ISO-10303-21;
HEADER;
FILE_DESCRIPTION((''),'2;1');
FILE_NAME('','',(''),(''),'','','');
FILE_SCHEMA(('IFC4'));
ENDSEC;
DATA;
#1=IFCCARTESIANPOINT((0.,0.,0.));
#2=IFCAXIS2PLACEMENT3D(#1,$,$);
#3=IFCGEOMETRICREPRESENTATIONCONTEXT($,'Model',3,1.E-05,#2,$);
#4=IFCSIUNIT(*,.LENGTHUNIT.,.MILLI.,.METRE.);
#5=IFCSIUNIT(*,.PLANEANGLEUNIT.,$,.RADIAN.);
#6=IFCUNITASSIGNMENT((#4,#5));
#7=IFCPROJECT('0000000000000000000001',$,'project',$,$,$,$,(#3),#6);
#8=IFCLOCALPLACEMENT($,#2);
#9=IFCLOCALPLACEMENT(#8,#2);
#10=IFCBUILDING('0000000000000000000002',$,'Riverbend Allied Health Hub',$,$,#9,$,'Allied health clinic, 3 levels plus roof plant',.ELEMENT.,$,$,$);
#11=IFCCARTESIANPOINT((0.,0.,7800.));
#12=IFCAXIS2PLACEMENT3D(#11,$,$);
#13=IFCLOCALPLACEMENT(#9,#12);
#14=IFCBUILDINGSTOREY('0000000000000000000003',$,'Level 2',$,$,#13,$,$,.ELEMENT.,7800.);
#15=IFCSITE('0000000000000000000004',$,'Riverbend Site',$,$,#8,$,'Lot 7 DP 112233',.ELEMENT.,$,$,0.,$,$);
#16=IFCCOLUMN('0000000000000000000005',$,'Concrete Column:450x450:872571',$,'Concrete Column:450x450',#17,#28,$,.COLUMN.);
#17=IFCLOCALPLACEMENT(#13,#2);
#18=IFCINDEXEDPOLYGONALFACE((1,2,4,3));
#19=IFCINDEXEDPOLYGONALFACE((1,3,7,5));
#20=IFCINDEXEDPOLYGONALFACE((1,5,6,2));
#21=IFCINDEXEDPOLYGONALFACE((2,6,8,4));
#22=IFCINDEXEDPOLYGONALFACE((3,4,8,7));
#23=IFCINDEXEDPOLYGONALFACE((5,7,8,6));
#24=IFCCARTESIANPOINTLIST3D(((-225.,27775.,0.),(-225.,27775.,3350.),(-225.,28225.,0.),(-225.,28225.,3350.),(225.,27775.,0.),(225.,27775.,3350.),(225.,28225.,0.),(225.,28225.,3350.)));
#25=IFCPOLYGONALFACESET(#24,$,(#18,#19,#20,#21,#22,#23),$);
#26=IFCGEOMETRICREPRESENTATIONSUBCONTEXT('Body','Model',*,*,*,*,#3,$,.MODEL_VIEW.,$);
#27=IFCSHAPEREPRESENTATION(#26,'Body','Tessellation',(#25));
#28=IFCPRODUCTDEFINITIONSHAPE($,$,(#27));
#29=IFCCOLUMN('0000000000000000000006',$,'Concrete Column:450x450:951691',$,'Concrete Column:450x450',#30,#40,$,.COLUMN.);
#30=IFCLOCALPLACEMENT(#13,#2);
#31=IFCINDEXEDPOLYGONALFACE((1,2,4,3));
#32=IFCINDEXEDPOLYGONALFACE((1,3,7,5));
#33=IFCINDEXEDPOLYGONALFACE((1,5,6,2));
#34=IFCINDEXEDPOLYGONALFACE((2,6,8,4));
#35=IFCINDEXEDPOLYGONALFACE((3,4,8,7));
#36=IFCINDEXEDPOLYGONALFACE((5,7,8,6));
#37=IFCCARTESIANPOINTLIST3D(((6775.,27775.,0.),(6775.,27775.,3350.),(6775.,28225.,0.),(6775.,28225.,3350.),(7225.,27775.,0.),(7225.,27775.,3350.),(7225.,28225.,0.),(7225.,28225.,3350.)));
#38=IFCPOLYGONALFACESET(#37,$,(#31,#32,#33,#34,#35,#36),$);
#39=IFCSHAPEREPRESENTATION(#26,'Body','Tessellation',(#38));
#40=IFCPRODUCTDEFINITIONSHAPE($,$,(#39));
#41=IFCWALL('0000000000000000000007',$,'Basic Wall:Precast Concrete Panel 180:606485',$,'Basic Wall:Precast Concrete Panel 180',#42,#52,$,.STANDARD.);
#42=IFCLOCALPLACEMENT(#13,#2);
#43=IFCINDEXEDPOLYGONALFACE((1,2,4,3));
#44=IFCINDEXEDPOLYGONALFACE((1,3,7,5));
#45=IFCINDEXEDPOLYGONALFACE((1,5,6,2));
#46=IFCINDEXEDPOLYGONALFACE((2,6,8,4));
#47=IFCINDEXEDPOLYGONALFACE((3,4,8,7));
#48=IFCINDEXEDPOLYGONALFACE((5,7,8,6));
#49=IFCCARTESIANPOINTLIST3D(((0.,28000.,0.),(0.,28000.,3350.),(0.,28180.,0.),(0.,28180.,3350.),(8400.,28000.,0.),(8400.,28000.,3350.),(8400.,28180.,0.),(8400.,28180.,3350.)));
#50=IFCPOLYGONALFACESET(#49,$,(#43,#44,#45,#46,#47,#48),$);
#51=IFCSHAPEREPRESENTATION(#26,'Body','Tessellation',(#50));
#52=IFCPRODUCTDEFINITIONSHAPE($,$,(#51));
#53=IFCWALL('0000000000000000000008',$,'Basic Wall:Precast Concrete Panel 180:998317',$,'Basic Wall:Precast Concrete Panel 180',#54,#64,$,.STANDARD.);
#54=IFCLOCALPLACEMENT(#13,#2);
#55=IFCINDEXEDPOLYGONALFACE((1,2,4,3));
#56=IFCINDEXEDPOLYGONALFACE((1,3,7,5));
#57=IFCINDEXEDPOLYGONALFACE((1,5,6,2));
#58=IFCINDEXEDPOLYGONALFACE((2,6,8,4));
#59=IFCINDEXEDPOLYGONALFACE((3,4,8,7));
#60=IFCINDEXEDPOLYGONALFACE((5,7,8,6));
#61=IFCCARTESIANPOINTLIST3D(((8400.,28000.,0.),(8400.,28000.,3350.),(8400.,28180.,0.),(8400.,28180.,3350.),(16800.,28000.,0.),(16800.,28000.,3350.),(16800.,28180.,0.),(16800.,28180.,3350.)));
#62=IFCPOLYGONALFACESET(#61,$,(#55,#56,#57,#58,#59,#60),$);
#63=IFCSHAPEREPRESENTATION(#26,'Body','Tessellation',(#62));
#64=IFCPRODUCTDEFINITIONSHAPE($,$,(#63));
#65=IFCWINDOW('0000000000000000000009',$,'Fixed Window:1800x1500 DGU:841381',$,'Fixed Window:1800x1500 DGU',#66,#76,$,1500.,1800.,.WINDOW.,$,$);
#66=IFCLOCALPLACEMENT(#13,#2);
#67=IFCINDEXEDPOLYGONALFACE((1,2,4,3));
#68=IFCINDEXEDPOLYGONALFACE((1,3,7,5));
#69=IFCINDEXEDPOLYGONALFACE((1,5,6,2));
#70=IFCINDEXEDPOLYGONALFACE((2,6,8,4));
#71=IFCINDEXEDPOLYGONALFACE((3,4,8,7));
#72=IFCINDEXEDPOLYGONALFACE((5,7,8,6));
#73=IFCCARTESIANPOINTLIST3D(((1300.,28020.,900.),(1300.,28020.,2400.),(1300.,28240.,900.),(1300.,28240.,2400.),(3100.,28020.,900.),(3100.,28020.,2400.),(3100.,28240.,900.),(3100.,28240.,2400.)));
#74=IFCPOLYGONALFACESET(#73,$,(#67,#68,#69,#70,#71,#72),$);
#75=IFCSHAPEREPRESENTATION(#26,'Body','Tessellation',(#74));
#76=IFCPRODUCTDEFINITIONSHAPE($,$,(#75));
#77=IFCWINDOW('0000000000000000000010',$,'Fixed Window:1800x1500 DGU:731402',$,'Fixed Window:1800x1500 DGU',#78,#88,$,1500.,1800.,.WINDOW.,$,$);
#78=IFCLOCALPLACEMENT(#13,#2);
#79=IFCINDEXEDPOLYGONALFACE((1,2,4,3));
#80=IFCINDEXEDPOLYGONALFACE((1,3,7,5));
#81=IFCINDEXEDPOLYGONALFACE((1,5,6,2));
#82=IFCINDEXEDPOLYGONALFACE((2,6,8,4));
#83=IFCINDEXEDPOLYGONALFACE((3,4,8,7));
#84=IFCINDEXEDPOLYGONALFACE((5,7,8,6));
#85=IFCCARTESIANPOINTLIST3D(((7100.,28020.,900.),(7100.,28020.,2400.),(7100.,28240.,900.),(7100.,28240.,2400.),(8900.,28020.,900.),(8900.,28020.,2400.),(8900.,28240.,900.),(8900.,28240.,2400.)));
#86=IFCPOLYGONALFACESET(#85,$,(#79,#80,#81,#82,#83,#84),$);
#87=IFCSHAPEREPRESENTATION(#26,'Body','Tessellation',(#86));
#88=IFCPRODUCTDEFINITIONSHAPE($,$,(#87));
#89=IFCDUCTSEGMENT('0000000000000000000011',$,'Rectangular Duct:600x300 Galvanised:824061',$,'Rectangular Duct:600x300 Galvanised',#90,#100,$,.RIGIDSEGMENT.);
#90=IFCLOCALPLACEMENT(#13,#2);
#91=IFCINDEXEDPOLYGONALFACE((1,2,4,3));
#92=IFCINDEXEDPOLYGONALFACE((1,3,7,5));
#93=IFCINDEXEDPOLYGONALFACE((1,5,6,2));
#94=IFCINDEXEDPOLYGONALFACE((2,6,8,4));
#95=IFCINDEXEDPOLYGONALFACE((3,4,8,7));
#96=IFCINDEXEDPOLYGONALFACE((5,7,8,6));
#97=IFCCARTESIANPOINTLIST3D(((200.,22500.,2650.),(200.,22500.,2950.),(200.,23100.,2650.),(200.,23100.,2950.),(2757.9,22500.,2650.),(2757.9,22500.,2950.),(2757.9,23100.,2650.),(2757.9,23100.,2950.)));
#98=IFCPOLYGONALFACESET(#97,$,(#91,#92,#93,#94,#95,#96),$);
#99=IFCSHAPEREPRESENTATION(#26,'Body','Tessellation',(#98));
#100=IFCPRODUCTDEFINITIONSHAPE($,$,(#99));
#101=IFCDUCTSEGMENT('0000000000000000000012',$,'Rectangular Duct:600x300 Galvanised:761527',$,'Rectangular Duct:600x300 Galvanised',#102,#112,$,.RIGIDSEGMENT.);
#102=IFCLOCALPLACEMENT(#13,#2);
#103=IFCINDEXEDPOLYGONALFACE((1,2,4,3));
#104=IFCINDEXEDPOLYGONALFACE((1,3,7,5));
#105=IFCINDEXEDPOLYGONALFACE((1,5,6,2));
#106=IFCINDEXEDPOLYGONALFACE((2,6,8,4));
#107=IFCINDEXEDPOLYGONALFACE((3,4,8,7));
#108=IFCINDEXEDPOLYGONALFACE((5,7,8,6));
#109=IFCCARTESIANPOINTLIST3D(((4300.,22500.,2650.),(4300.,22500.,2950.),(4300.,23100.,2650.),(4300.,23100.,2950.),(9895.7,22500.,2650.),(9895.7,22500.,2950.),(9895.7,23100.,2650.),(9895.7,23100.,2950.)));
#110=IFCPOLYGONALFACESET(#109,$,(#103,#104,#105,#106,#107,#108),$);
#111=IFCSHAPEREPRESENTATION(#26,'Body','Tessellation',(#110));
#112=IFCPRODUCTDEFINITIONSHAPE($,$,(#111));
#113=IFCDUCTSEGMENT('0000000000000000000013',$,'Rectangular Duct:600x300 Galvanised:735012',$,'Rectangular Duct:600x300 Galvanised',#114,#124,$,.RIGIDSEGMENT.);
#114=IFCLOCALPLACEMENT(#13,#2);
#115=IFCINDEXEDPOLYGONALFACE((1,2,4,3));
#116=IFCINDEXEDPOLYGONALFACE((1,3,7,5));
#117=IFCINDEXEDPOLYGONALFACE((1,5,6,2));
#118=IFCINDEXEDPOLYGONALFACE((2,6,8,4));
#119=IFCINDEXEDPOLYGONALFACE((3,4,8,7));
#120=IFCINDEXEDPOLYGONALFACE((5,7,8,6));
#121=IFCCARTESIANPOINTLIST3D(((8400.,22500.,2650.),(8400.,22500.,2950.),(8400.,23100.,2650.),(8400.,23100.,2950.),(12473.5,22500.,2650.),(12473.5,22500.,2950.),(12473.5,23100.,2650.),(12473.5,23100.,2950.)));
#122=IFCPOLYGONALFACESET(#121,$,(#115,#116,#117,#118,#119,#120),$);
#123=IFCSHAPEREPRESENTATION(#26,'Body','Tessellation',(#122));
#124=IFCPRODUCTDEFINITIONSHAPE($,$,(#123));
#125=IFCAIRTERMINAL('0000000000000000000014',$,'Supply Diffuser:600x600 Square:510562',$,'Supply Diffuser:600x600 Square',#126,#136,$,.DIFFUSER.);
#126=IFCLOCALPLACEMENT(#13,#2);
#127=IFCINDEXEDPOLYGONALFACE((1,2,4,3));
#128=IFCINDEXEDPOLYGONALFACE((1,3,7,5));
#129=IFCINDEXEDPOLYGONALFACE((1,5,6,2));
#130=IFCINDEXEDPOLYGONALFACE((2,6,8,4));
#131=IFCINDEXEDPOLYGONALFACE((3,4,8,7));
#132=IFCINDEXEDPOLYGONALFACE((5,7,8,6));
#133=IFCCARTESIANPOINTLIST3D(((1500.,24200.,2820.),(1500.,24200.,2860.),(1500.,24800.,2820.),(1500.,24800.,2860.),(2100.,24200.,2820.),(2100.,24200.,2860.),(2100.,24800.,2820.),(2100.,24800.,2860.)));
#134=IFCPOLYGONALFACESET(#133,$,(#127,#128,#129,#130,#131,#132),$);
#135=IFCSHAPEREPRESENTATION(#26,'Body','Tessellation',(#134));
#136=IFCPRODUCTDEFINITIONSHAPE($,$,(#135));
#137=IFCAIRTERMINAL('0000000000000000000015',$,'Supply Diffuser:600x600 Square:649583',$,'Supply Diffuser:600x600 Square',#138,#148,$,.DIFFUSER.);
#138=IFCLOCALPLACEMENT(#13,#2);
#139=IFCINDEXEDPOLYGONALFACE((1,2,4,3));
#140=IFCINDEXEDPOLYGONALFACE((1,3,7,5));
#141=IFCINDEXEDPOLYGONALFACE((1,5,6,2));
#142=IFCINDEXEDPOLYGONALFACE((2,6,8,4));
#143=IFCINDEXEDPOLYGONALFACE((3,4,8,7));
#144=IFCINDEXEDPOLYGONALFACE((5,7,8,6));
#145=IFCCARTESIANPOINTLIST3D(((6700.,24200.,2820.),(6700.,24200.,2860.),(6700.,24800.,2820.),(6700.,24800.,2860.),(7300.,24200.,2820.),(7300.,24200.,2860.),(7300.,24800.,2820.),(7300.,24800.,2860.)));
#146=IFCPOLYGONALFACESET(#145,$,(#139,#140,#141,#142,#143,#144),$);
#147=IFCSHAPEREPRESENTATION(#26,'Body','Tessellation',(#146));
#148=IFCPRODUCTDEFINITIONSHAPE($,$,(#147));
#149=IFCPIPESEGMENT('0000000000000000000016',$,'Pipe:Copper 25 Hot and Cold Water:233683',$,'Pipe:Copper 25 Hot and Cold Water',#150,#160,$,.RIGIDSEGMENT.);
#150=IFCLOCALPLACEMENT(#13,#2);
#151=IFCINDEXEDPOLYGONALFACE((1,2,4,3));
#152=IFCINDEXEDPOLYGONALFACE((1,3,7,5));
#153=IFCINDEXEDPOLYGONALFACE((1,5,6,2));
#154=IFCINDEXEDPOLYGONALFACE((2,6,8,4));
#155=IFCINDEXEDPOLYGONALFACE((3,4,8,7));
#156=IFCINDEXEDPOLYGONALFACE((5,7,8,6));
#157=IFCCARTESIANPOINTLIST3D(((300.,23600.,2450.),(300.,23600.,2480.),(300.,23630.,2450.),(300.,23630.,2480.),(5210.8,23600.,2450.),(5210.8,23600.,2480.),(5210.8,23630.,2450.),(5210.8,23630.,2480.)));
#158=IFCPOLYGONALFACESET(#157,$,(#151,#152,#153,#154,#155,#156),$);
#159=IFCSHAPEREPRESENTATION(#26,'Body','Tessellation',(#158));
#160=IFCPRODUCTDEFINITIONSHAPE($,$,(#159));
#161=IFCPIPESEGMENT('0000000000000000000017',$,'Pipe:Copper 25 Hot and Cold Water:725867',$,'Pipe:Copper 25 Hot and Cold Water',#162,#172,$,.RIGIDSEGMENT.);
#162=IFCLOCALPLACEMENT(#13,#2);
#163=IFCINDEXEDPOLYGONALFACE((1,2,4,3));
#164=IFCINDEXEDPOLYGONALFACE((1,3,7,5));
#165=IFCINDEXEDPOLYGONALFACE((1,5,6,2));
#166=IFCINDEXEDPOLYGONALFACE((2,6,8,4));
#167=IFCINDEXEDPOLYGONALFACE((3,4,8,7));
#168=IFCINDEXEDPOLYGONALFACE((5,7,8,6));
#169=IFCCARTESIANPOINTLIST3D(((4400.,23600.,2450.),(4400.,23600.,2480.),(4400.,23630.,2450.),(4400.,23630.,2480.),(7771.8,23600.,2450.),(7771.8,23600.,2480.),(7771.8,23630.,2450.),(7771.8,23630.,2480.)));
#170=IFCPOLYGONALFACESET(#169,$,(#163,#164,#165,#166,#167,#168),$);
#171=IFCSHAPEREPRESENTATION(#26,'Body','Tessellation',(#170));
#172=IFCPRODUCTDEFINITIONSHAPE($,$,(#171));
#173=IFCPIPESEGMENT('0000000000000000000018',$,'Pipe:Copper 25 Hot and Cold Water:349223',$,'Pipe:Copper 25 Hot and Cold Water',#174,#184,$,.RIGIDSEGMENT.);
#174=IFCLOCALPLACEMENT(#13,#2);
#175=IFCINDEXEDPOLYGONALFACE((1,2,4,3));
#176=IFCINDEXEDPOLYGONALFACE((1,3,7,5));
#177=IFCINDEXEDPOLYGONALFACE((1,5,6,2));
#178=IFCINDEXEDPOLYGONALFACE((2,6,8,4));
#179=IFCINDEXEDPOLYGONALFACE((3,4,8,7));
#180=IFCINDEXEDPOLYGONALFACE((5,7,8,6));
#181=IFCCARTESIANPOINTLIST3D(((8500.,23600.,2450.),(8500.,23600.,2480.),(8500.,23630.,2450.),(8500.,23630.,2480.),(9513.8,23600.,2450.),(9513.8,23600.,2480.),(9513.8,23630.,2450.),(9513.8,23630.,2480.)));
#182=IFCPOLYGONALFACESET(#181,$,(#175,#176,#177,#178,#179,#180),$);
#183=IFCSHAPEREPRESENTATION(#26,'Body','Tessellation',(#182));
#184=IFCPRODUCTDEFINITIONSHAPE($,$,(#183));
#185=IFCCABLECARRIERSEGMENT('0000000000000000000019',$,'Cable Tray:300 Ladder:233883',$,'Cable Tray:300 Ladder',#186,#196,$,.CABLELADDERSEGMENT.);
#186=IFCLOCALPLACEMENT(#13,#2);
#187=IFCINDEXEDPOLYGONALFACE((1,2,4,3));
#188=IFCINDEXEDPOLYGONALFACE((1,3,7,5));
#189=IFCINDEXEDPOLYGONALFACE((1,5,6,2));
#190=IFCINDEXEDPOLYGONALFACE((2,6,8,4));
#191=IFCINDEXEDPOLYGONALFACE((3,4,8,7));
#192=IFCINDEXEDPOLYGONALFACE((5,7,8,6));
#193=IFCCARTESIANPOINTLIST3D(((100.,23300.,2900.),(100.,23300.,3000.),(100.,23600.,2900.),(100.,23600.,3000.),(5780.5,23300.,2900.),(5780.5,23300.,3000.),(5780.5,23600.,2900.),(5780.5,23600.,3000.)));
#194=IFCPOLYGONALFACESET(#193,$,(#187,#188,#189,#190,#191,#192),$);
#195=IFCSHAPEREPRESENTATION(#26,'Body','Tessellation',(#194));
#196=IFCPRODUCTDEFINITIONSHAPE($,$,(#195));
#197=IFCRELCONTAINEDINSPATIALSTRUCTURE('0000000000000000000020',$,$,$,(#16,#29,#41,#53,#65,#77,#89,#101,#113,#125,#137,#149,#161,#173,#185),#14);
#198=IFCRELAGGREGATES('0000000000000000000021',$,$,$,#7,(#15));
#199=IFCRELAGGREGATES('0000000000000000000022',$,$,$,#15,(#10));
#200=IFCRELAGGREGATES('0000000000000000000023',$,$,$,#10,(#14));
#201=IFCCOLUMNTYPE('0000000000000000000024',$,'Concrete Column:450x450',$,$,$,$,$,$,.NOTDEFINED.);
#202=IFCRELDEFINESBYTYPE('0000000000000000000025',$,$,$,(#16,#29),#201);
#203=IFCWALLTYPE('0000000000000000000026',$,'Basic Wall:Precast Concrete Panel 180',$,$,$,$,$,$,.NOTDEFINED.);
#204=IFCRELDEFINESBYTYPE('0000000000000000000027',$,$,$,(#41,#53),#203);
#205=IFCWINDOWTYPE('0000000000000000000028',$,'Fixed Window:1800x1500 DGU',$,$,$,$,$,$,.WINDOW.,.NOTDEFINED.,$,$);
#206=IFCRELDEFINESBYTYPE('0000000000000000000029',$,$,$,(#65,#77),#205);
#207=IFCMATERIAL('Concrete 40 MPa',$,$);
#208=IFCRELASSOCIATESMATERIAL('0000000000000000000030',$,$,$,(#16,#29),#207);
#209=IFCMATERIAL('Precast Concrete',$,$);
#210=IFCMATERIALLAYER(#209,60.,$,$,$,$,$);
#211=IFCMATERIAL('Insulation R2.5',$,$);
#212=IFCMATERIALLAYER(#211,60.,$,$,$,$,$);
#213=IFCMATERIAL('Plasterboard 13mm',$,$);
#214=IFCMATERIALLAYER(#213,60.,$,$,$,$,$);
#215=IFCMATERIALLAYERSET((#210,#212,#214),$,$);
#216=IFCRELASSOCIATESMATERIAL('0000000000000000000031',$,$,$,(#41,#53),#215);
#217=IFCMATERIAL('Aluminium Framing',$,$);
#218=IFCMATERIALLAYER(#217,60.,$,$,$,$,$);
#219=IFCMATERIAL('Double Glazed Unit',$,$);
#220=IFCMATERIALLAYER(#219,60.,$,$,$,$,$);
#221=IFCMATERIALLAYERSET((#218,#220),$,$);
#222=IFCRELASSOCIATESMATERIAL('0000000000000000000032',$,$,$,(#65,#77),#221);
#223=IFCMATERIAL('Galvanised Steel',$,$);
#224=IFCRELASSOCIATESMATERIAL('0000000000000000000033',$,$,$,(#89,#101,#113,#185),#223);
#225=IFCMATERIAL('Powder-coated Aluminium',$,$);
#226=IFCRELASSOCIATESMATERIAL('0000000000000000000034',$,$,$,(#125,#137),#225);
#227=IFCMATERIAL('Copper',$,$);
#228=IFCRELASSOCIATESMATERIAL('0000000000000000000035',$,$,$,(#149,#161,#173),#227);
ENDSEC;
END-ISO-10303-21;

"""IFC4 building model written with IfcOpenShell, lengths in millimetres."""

from ifc_helpers import new_model, si_unit, frame, frame_2d, origin, place, context, subcontext, project, spatial, rectangle, extrude, material, layer, layer_set, layer_usage, type_object, element, save


model = new_model("IFC4")

# Units and contexts
model_context = context("Model", 3, precision=1e-05, world=origin())
body_context = subcontext(model_context, "Body", "Model", "MODEL_VIEW")
ifc_project = project(units=[si_unit("LENGTHUNIT", "METRE", prefix="MILLI"), si_unit("PLANEANGLEUNIT", "RADIAN")], contexts=[model_context])

# Site, building, storey
site_placement = place(None, origin())
site = spatial("IfcSite", under=ifc_project, at=site_placement, Name="Riverbend Site", LongName="Lot 7 DP 112233", CompositionType="ELEMENT", RefElevation=0.0)
building_placement = place(site_placement, origin())
building = spatial("IfcBuilding", under=site, at=building_placement, Name="Riverbend Allied Health Hub", LongName="Allied health clinic, 3 levels plus roof plant", CompositionType="ELEMENT")
storey_placement = place(building_placement, frame((0.0, 0.0, 7800.0)))
storey = spatial("IfcBuildingStorey", under=building, at=storey_placement, Name="Level 2", CompositionType="ELEMENT", Elevation=7800.0)

# Columns
ifc_material_1 = material(Name="Concrete 40 MPa")
column_type = type_object("IfcColumnType", Name="Concrete Column:450x450", PredefinedType="NOTDEFINED")
for number, where, name in (
    (1, (-225.0, 27775.0, 0.0), "Concrete Column:450x450:872571"),
    (2, (6775.0, 27775.0, 0.0), "Concrete Column:450x450:951691"),
):
    element("IfcColumn", number, at=place(storey_placement, frame(where)), inside=storey, type_object=column_type, material=ifc_material_1, Name=name, ObjectType="Concrete Column:450x450", PredefinedType="COLUMN", context=body_context, shape_type="SweptSolid", body=[
        extrude(rectangle(XDim=450.0, YDim=450.0, at=frame_2d((225.0, 225.0))), origin(), (0.0, 0.0, 1.0), 3350.0),
    ])

# Walls
ifc_material_2 = material(Name="Precast Concrete")
ifc_layer_1 = layer(ifc_material_2, 60.0)
ifc_material_3 = material(Name="Insulation R2.5")
ifc_layer_2 = layer(ifc_material_3, 60.0)
ifc_material_4 = material(Name="Plasterboard 13mm")
ifc_layer_3 = layer(ifc_material_4, 60.0)
ifc_layer_set_1 = layer_set([ifc_layer_1, ifc_layer_2, ifc_layer_3])
ifc_layer_usage_1 = layer_usage(ifc_layer_set_1, "AXIS2", "POSITIVE", 0.0)
wall_type = type_object("IfcWallType", Name="Basic Wall:Precast Concrete Panel 180", PredefinedType="NOTDEFINED")
for number, where, name in (
    (3, (0.0, 28000.0, 0.0), "Basic Wall:Precast Concrete Panel 180:606485"),
    (4, (8400.0, 28000.0, 0.0), "Basic Wall:Precast Concrete Panel 180:998317"),
):
    element("IfcWall", number, at=place(storey_placement, frame(where)), inside=storey, type_object=wall_type, material=ifc_layer_usage_1, Name=name, ObjectType="Basic Wall:Precast Concrete Panel 180", PredefinedType="STANDARD", context=body_context, shape_type="SweptSolid", body=[
        extrude(rectangle(XDim=8400.0, YDim=180.0, at=frame_2d((4200.0, 90.0))), origin(), (0.0, 0.0, 1.0), 3350.0),
    ])

# Windows
ifc_material_5 = material(Name="Aluminium Framing")
ifc_layer_4 = layer(ifc_material_5, 60.0)
ifc_material_6 = material(Name="Double Glazed Unit")
ifc_layer_5 = layer(ifc_material_6, 60.0)
ifc_layer_set_2 = layer_set([ifc_layer_4, ifc_layer_5])
ifc_layer_usage_2 = layer_usage(ifc_layer_set_2, "AXIS2", "POSITIVE", 0.0)
window_type = type_object("IfcWindowType", Name="Fixed Window:1800x1500 DGU", PartitioningType="NOTDEFINED", PredefinedType="WINDOW")
for number, where, name in (
    (5, (1300.0, 28020.0, 900.0), "Fixed Window:1800x1500 DGU:841381"),
    (6, (7100.0, 28020.0, 900.0), "Fixed Window:1800x1500 DGU:731402"),
):
    element("IfcWindow", number, at=place(storey_placement, frame(where)), inside=storey, type_object=window_type, material=ifc_layer_usage_2, Name=name, ObjectType="Fixed Window:1800x1500 DGU", OverallHeight=1500.0, OverallWidth=1800.0, PredefinedType="WINDOW", context=body_context, shape_type="SweptSolid", body=[
        extrude(rectangle(XDim=1800.0, YDim=220.0, at=frame_2d((900.0, 110.0))), origin(), (0.0, 0.0, 1.0), 1500.0),
    ])

# Duct segments
ifc_material_7 = material(Name="Galvanised Steel")
duct_segment_1_placement = place(storey_placement, frame((200.0, 22500.0, 2650.0)))
element("IfcDuctSegment", 7, at=duct_segment_1_placement, inside=storey, material=ifc_material_7, Name="Rectangular Duct:600x300 Galvanised:824061", ObjectType="Rectangular Duct:600x300 Galvanised", PredefinedType="RIGIDSEGMENT", context=body_context, shape_type="SweptSolid", body=[
    extrude(rectangle(XDim=2557.9, YDim=600.0, at=frame_2d((1278.9, 300.0))), origin(), (0.0, 0.0, 1.0), 300.0),
])
duct_segment_2_placement = place(storey_placement, frame((4300.0, 22500.0, 2650.0)))
element("IfcDuctSegment", 8, at=duct_segment_2_placement, inside=storey, material=ifc_material_7, Name="Rectangular Duct:600x300 Galvanised:761527", ObjectType="Rectangular Duct:600x300 Galvanised", PredefinedType="RIGIDSEGMENT", context=body_context, shape_type="SweptSolid", body=[
    extrude(rectangle(XDim=5595.7, YDim=600.0, at=frame_2d((2797.8, 300.0))), origin(), (0.0, 0.0, 1.0), 300.0),
])
duct_segment_3_placement = place(storey_placement, frame((8400.0, 22500.0, 2650.0)))
element("IfcDuctSegment", 9, at=duct_segment_3_placement, inside=storey, material=ifc_material_7, Name="Rectangular Duct:600x300 Galvanised:735012", ObjectType="Rectangular Duct:600x300 Galvanised", PredefinedType="RIGIDSEGMENT", context=body_context, shape_type="SweptSolid", body=[
    extrude(rectangle(XDim=4073.5, YDim=600.0, at=frame_2d((2036.7, 300.0))), origin(), (0.0, 0.0, 1.0), 300.0),
])

# Air terminals
ifc_material_8 = material(Name="Powder-coated Aluminium")
for number, where, name in (
    (10, (1500.0, 24200.0, 2820.0), "Supply Diffuser:600x600 Square:510562"),
    (11, (6700.0, 24200.0, 2820.0), "Supply Diffuser:600x600 Square:649583"),
):
    element("IfcAirTerminal", number, at=place(storey_placement, frame(where)), inside=storey, material=ifc_material_8, Name=name, ObjectType="Supply Diffuser:600x600 Square", PredefinedType="DIFFUSER", context=body_context, shape_type="SweptSolid", body=[
        extrude(rectangle(XDim=600.0, YDim=600.0, at=frame_2d((300.0, 300.0))), origin(), (0.0, 0.0, 1.0), 40.0),
    ])

# Pipe segments
ifc_material_9 = material(Name="Copper")
pipe_segment_1_placement = place(storey_placement, frame((300.0, 23600.0, 2450.0)))
element("IfcPipeSegment", 12, at=pipe_segment_1_placement, inside=storey, material=ifc_material_9, Name="Pipe:Copper 25 Hot and Cold Water:233683", ObjectType="Pipe:Copper 25 Hot and Cold Water", PredefinedType="RIGIDSEGMENT", context=body_context, shape_type="SweptSolid", body=[
    extrude(rectangle(XDim=4910.8, YDim=30.0, at=frame_2d((2455.4, 15.0))), origin(), (0.0, 0.0, 1.0), 30.0),
])
pipe_segment_2_placement = place(storey_placement, frame((4400.0, 23600.0, 2450.0)))
element("IfcPipeSegment", 13, at=pipe_segment_2_placement, inside=storey, material=ifc_material_9, Name="Pipe:Copper 25 Hot and Cold Water:725867", ObjectType="Pipe:Copper 25 Hot and Cold Water", PredefinedType="RIGIDSEGMENT", context=body_context, shape_type="SweptSolid", body=[
    extrude(rectangle(XDim=3371.8, YDim=30.0, at=frame_2d((1685.9, 15.0))), origin(), (0.0, 0.0, 1.0), 30.0),
])
pipe_segment_3_placement = place(storey_placement, frame((8500.0, 23600.0, 2450.0)))
element("IfcPipeSegment", 14, at=pipe_segment_3_placement, inside=storey, material=ifc_material_9, Name="Pipe:Copper 25 Hot and Cold Water:349223", ObjectType="Pipe:Copper 25 Hot and Cold Water", PredefinedType="RIGIDSEGMENT", context=body_context, shape_type="SweptSolid", body=[
    extrude(rectangle(XDim=1013.8, YDim=30.0, at=frame_2d((506.9, 15.0))), origin(), (0.0, 0.0, 1.0), 30.0),
])

# Cable carrier segment
cable_carrier_segment_1_placement = place(storey_placement, frame((100.0, 23300.0, 2900.0)))
element("IfcCableCarrierSegment", 15, at=cable_carrier_segment_1_placement, inside=storey, material=ifc_material_7, Name="Cable Tray:300 Ladder:233883", ObjectType="Cable Tray:300 Ladder", PredefinedType="CABLELADDERSEGMENT", context=body_context, shape_type="SweptSolid", body=[
    extrude(rectangle(XDim=5680.5, YDim=300.0, at=frame_2d((2840.3, 150.0))), origin(), (0.0, 0.0, 1.0), 100.0),
])

save(model, "model.ifc")
